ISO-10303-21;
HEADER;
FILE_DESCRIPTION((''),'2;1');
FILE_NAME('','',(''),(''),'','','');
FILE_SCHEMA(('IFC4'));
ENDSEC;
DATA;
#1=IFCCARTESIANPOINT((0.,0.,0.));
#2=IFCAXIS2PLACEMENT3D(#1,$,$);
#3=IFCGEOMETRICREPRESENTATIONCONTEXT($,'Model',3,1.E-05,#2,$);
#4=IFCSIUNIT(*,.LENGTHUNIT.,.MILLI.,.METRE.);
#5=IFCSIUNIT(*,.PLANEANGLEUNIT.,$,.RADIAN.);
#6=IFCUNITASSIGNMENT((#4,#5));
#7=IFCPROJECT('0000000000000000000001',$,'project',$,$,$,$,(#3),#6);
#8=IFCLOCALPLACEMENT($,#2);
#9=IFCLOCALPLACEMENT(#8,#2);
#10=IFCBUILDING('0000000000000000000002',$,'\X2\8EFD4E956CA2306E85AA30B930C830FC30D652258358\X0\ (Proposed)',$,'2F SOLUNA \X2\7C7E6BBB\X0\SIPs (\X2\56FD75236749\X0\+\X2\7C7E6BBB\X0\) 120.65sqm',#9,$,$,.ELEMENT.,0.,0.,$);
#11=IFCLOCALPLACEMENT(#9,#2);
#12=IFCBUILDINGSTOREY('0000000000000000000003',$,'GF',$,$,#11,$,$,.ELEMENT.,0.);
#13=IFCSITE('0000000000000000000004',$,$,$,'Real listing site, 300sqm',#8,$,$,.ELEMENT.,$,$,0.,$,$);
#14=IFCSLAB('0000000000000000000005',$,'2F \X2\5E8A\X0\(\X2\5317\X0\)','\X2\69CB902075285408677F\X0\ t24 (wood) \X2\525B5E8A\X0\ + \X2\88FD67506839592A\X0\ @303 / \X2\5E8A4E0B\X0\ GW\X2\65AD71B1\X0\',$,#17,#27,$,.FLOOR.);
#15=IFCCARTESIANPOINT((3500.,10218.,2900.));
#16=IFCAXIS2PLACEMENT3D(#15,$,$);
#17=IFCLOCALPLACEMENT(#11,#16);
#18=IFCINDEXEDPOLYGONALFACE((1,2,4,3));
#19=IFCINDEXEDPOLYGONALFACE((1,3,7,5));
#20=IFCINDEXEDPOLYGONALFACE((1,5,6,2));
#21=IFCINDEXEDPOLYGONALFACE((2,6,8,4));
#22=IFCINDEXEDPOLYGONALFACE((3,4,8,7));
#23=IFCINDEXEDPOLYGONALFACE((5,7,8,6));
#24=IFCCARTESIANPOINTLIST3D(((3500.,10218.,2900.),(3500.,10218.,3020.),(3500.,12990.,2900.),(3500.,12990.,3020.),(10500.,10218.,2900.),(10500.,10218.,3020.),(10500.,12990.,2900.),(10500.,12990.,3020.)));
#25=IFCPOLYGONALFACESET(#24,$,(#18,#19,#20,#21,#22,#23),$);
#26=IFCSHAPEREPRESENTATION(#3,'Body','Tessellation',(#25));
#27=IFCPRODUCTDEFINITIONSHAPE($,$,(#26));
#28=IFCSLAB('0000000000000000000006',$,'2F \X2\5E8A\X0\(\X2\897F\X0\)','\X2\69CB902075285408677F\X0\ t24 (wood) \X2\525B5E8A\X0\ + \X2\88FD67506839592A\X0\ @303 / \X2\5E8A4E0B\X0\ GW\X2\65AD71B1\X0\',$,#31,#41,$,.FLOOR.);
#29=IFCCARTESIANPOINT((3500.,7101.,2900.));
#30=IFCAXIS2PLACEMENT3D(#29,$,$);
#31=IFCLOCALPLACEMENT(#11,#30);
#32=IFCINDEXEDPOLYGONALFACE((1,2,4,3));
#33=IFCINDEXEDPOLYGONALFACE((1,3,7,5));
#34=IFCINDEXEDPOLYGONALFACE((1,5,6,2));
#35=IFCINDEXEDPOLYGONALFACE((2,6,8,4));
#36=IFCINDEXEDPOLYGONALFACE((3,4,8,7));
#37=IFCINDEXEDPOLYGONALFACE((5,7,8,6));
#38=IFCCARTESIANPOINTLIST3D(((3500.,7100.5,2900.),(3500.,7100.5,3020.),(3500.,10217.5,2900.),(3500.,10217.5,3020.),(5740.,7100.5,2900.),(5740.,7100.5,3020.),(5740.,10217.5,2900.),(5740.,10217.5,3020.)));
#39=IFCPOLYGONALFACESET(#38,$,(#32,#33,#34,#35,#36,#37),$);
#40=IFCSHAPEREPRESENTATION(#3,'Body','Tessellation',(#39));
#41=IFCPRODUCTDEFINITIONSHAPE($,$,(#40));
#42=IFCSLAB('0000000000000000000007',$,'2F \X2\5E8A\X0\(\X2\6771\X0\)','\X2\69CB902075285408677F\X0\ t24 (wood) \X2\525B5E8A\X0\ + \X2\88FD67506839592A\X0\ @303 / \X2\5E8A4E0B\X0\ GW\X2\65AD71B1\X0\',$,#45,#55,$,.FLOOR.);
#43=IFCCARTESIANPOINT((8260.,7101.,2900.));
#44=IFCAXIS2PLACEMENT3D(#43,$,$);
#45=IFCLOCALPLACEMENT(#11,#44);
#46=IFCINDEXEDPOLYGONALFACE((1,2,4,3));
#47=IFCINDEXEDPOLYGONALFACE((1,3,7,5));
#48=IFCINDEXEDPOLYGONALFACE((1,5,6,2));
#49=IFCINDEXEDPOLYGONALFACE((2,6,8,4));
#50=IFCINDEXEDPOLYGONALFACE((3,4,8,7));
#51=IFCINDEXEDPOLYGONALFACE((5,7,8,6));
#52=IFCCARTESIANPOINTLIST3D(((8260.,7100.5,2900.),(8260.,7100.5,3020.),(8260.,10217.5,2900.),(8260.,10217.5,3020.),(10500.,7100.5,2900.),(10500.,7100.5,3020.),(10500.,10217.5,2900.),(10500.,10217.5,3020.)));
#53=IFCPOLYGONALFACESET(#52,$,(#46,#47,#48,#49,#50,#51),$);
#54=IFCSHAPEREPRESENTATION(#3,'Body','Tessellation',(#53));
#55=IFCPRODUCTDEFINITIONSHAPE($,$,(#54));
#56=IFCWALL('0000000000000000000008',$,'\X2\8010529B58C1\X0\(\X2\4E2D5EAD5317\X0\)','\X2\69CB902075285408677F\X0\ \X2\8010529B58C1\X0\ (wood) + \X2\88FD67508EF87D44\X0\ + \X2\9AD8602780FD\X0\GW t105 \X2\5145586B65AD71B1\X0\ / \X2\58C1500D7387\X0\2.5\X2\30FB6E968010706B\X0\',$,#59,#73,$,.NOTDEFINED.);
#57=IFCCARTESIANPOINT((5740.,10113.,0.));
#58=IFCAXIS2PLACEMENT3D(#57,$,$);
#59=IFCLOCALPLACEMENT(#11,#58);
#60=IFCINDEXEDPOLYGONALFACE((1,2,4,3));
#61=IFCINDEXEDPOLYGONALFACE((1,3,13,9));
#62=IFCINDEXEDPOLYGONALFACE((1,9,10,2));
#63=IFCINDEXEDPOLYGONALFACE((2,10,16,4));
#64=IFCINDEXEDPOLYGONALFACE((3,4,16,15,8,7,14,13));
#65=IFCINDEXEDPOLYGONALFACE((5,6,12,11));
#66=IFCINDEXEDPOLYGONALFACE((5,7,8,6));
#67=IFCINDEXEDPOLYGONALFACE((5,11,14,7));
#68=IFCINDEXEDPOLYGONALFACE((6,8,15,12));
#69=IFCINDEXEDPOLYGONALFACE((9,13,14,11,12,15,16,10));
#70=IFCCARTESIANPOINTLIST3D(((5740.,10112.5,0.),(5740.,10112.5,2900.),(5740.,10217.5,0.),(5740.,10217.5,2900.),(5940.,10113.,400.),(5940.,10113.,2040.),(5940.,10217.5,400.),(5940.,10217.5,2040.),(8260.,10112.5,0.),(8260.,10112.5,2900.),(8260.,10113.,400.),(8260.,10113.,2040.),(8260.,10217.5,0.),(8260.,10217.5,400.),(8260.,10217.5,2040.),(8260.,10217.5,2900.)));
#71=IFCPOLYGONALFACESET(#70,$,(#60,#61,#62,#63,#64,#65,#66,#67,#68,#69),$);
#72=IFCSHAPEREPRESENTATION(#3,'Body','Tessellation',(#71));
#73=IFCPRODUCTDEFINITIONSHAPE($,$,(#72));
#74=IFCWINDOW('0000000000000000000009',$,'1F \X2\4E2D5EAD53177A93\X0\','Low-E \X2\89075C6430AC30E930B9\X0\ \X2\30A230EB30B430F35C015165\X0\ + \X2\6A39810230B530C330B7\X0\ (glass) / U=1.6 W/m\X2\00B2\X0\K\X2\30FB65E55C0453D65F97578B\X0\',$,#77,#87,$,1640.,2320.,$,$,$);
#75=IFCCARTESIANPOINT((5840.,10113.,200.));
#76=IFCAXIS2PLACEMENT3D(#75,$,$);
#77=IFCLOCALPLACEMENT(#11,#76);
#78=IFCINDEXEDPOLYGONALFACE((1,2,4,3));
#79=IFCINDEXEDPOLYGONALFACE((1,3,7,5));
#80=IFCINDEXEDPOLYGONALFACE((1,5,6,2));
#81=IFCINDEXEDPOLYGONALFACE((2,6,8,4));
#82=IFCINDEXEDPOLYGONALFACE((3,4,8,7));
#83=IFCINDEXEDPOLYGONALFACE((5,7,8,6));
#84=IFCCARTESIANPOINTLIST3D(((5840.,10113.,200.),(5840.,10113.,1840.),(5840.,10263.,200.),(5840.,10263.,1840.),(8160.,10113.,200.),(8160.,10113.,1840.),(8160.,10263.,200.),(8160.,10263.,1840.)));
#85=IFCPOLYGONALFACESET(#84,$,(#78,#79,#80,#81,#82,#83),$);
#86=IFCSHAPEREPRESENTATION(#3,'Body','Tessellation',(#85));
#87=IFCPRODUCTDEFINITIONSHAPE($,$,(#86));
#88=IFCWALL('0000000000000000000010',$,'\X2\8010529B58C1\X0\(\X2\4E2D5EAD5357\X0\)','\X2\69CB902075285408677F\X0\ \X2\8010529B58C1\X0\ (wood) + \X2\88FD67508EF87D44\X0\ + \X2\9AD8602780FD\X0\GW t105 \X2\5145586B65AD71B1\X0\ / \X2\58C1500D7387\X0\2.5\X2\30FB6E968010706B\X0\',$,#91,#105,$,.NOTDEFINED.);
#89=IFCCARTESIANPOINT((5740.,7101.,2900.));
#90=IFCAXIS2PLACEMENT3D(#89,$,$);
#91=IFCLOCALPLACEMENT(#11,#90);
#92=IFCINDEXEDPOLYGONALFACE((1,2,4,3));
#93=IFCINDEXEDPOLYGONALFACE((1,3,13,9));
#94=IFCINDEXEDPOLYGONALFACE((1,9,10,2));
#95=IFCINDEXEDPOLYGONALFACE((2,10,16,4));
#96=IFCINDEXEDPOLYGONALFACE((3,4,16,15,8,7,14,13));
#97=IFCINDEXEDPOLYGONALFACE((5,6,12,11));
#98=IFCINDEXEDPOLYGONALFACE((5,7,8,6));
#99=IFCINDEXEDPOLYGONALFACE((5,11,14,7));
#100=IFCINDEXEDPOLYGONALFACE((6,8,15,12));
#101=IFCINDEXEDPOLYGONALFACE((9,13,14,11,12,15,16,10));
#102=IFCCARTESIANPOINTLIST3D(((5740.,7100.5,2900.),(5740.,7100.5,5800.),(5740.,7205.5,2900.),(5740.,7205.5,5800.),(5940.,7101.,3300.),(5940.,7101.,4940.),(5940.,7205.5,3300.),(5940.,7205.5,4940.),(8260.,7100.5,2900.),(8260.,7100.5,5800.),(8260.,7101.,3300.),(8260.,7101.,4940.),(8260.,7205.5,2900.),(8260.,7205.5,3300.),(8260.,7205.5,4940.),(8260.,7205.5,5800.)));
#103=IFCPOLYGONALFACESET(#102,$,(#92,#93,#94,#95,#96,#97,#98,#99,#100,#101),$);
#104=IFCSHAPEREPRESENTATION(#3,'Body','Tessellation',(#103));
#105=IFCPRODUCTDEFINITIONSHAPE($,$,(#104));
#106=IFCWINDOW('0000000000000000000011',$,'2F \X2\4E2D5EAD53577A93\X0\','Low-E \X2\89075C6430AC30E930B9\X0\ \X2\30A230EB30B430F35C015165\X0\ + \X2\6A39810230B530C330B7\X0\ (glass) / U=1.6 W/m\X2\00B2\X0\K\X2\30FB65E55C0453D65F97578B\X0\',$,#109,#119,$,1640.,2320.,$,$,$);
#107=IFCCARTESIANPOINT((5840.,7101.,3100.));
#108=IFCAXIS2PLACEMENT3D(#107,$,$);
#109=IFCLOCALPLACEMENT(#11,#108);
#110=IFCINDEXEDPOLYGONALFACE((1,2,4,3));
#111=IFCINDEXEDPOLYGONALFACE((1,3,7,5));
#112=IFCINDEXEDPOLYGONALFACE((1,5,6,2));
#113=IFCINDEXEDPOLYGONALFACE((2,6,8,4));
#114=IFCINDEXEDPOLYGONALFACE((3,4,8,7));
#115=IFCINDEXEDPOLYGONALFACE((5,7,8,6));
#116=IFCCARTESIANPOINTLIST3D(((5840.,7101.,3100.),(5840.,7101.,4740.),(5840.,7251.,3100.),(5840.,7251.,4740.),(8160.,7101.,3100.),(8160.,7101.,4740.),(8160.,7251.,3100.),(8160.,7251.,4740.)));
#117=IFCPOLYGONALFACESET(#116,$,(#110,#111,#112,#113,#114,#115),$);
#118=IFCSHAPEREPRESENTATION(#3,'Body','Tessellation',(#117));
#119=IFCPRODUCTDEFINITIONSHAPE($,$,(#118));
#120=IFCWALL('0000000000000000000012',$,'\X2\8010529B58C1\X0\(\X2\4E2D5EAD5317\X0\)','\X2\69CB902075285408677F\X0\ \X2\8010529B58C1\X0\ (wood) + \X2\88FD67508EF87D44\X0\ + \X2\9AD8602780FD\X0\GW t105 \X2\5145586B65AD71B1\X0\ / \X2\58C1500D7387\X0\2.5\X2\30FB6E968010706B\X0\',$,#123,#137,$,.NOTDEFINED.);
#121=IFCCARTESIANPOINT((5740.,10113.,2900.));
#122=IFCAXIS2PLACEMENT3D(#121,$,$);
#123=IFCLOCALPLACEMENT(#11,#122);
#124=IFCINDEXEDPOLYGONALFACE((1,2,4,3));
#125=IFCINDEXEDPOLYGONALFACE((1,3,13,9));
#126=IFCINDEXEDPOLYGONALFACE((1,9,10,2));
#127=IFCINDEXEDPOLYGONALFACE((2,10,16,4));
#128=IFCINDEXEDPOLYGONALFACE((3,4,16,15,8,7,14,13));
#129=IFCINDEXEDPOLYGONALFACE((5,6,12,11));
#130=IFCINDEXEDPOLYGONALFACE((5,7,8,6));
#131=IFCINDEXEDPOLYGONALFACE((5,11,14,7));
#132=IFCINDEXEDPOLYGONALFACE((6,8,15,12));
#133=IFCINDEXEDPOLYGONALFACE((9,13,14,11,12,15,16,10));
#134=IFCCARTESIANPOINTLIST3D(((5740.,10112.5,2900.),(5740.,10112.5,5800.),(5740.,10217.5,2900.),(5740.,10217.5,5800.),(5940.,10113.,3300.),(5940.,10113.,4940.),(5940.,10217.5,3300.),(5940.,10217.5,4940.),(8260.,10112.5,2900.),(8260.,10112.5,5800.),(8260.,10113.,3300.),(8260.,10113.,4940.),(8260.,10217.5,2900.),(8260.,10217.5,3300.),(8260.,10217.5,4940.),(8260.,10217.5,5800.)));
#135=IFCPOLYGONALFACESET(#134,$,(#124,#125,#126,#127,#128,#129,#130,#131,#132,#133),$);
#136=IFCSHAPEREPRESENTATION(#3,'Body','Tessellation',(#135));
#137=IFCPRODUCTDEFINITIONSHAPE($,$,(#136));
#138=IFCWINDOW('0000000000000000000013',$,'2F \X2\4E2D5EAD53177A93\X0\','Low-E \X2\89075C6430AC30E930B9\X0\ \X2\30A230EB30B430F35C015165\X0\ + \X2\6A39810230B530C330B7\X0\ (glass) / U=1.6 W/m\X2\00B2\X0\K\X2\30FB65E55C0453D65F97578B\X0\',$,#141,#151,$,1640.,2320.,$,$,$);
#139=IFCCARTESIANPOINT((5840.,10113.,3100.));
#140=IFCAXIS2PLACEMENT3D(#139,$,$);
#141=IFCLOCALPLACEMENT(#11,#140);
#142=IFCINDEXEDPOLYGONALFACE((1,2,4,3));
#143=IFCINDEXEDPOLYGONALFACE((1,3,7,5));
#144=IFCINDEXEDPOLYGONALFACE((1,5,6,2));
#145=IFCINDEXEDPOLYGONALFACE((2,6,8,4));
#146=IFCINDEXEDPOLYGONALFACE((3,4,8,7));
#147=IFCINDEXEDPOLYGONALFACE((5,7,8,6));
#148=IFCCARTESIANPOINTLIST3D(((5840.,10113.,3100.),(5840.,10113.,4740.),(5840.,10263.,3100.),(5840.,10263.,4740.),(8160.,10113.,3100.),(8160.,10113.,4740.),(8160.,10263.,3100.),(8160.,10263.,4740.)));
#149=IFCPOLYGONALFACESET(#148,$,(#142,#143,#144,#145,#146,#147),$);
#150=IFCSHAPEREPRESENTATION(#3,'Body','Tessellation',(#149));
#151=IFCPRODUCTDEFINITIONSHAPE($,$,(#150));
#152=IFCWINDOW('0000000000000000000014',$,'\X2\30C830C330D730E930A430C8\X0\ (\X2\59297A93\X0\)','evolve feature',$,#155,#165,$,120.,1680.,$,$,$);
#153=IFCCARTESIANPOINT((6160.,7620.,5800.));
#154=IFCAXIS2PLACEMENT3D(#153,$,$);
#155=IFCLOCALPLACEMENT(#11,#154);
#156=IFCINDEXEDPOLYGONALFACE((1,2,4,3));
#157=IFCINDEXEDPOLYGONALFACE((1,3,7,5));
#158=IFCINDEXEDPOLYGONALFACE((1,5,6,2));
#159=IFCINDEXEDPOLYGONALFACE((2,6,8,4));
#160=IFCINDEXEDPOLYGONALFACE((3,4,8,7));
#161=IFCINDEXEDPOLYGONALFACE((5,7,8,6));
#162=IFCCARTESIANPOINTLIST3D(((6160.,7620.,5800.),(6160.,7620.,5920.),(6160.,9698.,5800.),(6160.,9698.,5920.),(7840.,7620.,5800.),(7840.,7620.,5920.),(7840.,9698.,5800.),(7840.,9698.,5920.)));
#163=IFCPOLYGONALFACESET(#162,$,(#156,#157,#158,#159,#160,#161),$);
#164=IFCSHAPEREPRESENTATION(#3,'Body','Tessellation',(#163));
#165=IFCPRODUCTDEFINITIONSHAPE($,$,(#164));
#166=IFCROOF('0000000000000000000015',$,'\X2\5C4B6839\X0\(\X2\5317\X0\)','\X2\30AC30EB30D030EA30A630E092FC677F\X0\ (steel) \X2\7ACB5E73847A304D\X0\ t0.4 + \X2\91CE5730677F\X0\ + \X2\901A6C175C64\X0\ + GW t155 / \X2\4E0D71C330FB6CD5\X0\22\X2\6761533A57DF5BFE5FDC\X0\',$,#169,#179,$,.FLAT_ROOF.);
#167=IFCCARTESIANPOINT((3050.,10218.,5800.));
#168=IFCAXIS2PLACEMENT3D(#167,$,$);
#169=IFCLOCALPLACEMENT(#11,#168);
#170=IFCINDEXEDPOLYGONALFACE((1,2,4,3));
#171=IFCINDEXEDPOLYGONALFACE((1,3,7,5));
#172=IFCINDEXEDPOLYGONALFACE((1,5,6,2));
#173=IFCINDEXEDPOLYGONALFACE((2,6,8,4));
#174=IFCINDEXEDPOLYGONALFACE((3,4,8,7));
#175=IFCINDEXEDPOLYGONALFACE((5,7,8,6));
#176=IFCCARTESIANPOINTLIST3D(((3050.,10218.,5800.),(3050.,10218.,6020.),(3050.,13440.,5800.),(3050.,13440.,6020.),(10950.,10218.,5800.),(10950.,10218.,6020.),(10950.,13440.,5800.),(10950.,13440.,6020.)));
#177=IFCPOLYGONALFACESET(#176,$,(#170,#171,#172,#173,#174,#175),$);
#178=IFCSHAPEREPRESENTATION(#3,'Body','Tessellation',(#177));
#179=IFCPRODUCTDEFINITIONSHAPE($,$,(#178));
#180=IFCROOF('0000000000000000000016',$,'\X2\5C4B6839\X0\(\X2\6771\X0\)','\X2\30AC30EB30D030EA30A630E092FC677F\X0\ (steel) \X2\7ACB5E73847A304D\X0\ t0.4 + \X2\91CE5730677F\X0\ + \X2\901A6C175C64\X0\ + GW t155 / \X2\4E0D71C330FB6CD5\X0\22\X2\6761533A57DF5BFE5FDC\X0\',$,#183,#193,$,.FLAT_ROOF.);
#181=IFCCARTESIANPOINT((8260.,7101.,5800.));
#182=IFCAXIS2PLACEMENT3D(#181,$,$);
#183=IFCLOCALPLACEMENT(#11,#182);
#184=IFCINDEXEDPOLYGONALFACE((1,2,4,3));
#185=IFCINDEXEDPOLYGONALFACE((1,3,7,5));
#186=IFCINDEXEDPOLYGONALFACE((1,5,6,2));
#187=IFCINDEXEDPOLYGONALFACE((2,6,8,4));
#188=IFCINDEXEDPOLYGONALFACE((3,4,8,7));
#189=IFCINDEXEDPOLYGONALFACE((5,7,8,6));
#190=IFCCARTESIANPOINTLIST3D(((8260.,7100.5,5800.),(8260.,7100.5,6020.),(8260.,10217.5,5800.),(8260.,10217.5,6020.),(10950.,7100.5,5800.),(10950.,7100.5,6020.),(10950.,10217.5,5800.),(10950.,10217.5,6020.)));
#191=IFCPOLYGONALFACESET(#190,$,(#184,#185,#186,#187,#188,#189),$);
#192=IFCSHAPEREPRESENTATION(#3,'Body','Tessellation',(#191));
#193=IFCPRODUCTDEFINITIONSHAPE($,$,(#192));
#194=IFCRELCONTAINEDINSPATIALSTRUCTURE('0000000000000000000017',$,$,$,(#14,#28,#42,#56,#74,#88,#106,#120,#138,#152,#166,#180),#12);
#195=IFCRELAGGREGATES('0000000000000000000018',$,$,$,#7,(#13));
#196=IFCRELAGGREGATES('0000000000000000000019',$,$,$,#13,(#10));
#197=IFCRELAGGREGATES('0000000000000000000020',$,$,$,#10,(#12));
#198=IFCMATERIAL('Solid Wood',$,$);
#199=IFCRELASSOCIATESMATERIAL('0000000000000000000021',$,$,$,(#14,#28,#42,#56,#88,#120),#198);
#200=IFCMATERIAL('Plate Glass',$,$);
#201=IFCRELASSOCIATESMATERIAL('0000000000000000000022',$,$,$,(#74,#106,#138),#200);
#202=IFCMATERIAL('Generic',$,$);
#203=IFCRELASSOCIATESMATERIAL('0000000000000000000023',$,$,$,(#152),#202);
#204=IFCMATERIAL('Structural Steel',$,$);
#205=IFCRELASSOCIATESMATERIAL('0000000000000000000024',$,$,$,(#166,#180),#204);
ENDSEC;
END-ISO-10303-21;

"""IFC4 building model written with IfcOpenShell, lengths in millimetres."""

from ifc_helpers import new_model, si_unit, frame, frame_2d, origin, place, context, project, spatial, rectangle, extrude, material, element, fill, save


model = new_model("IFC4")

# Units and contexts
model_context = context("Model", 3, precision=1e-05, world=origin())
ifc_project = project(units=[si_unit("LENGTHUNIT", "METRE", prefix="MILLI"), si_unit("PLANEANGLEUNIT", "RADIAN")], contexts=[model_context])

# Site, building, storey
site_placement = place(None, origin())
site = spatial("IfcSite", under=ifc_project, at=site_placement, ObjectType="Real listing site, 300sqm", CompositionType="ELEMENT", RefElevation=0.0)
building_placement = place(site_placement, origin())
building = spatial("IfcBuilding", under=site, at=building_placement, Name="軽井沢の薪ストーブ別荘 (Proposed)", ObjectType="2F SOLUNA 籾殻SIPs (国産杉+籾殻) 120.65sqm", CompositionType="ELEMENT", ElevationOfRefHeight=0.0, ElevationOfTerrain=0.0)
storey_placement = place(building_placement, origin())
storey = spatial("IfcBuildingStorey", under=building, at=storey_placement, Name="GF", CompositionType="ELEMENT", Elevation=0.0)

# Slabs
ifc_material_1 = material(Name="Solid Wood")
slab_1_placement = place(storey_placement, frame((3500.0, 10218.0, 2900.0)))
element("IfcSlab", 1, at=slab_1_placement, inside=storey, material=ifc_material_1, Name="2F 床(北)", Description="構造用合板 t24 (wood) 剛床 + 製材根太 @303 / 床下 GW断熱", PredefinedType="FLOOR", context=model_context, shape_type="SweptSolid", body=[
    extrude(rectangle(XDim=7000.0, YDim=2772.0, at=frame_2d((3500.0, 1386.0))), frame((3500.0, 10218.0, 2900.0)), (0.0, 0.0, 1.0), 120.0),
])
slab_2_placement = place(storey_placement, frame((3500.0, 7101.0, 2900.0)))
element("IfcSlab", 2, at=slab_2_placement, inside=storey, material=ifc_material_1, Name="2F 床(西)", Description="構造用合板 t24 (wood) 剛床 + 製材根太 @303 / 床下 GW断熱", PredefinedType="FLOOR", context=model_context, shape_type="SweptSolid", body=[
    extrude(rectangle(XDim=2240.0, YDim=3117.0, at=frame_2d((1120.0, 1558.0))), frame((3500.0, 7101.0, 2900.0)), (0.0, 0.0, 1.0), 120.0),
])
slab_3_placement = place(storey_placement, frame((8260.0, 7101.0, 2900.0)))
element("IfcSlab", 3, at=slab_3_placement, inside=storey, material=ifc_material_1, Name="2F 床(東)", Description="構造用合板 t24 (wood) 剛床 + 製材根太 @303 / 床下 GW断熱", PredefinedType="FLOOR", context=model_context, shape_type="SweptSolid", body=[
    extrude(rectangle(XDim=2240.0, YDim=3117.0, at=frame_2d((1120.0, 1558.0))), frame((8260.0, 7101.0, 2900.0)), (0.0, 0.0, 1.0), 120.0),
])

# Wall, opening, window
wall_1_placement = place(storey_placement, frame((5740.0, 10113.0, 0.0)))
wall_1 = element("IfcWall", 4, at=wall_1_placement, inside=storey, material=ifc_material_1, Name="耐力壁(中庭北)", Description="構造用合板 耐力壁 (wood) + 製材軸組 + 高性能GW t105 充填断熱 / 壁倍率2.5・準耐火", PredefinedType="NOTDEFINED", context=model_context, shape_type="SweptSolid", body=[
    extrude(rectangle(XDim=2520.0, YDim=105.0, at=frame_2d((1260.0, 52.0))), frame((5740.0, 10113.0, 0.0)), (0.0, 0.0, 1.0), 2900.0),
])
opening_1_placement = place(storey_placement, frame((5840.0, 10113.0, 200.0)))
opening_1 = element("IfcOpeningElement", 5, at=opening_1_placement, cuts=wall_1, PredefinedType="NOTDEFINED", context=model_context, shape_type="SweptSolid", body=[
    extrude(rectangle(XDim=2320.0, YDim=150.0, at=frame_2d((1160.0, 75.0))), frame((5840.0, 10113.0, 200.0)), (0.0, 0.0, 1.0), 1640.0),
])
ifc_material_2 = material(Name="Plate Glass")
window_1_placement = place(storey_placement, frame((5840.0, 10113.0, 200.0)))
window_1 = element("IfcWindow", 6, at=window_1_placement, inside=storey, material=ifc_material_2, Name="1F 中庭北窓", Description="Low-E 複層ガラス アルゴン封入 + 樹脂サッシ (glass) / U=1.6 W/m²K・日射取得型", OverallHeight=1640.0, OverallWidth=2320.0, context=model_context, shape_type="SweptSolid", body=[
    extrude(rectangle(XDim=2320.0, YDim=150.0, at=frame_2d((1160.0, 75.0))), frame((5840.0, 10113.0, 200.0)), (0.0, 0.0, 1.0), 1640.0),
])
fill(opening_1, window_1)

# Walls, openings, windows
wall_2_placement = place(storey_placement, frame((5740.0, 7101.0, 2900.0)))
wall_2 = element("IfcWall", 7, at=wall_2_placement, inside=storey, material=ifc_material_1, Name="耐力壁(中庭南)", Description="構造用合板 耐力壁 (wood) + 製材軸組 + 高性能GW t105 充填断熱 / 壁倍率2.5・準耐火", PredefinedType="NOTDEFINED", context=model_context, shape_type="SweptSolid", body=[
    extrude(rectangle(XDim=2520.0, YDim=105.0, at=frame_2d((1260.0, 52.0))), frame((5740.0, 7101.0, 2900.0)), (0.0, 0.0, 1.0), 2900.0),
])
opening_2_placement = place(storey_placement, frame((5840.0, 7101.0, 3100.0)))
opening_2 = element("IfcOpeningElement", 8, at=opening_2_placement, cuts=wall_2, PredefinedType="NOTDEFINED", context=model_context, shape_type="SweptSolid", body=[
    extrude(rectangle(XDim=2320.0, YDim=150.0, at=frame_2d((1160.0, 75.0))), frame((5840.0, 7101.0, 3100.0)), (0.0, 0.0, 1.0), 1640.0),
])
window_2_placement = place(storey_placement, frame((5840.0, 7101.0, 3100.0)))
window_2 = element("IfcWindow", 9, at=window_2_placement, inside=storey, material=ifc_material_2, Name="2F 中庭南窓", Description="Low-E 複層ガラス アルゴン封入 + 樹脂サッシ (glass) / U=1.6 W/m²K・日射取得型", OverallHeight=1640.0, OverallWidth=2320.0, context=model_context, shape_type="SweptSolid", body=[
    extrude(rectangle(XDim=2320.0, YDim=150.0, at=frame_2d((1160.0, 75.0))), frame((5840.0, 7101.0, 3100.0)), (0.0, 0.0, 1.0), 1640.0),
])
fill(opening_2, window_2)
wall_3_placement = place(storey_placement, frame((5740.0, 10113.0, 2900.0)))
wall_3 = element("IfcWall", 10, at=wall_3_placement, inside=storey, material=ifc_material_1, Name="耐力壁(中庭北)", Description="構造用合板 耐力壁 (wood) + 製材軸組 + 高性能GW t105 充填断熱 / 壁倍率2.5・準耐火", PredefinedType="NOTDEFINED", context=model_context, shape_type="SweptSolid", body=[
    extrude(rectangle(XDim=2520.0, YDim=105.0, at=frame_2d((1260.0, 52.0))), frame((5740.0, 10113.0, 2900.0)), (0.0, 0.0, 1.0), 2900.0),
])
opening_3_placement = place(storey_placement, frame((5840.0, 10113.0, 3100.0)))
opening_3 = element("IfcOpeningElement", 11, at=opening_3_placement, cuts=wall_3, PredefinedType="NOTDEFINED", context=model_context, shape_type="SweptSolid", body=[
    extrude(rectangle(XDim=2320.0, YDim=150.0, at=frame_2d((1160.0, 75.0))), frame((5840.0, 10113.0, 3100.0)), (0.0, 0.0, 1.0), 1640.0),
])
window_3_placement = place(storey_placement, frame((5840.0, 10113.0, 3100.0)))
window_3 = element("IfcWindow", 12, at=window_3_placement, inside=storey, material=ifc_material_2, Name="2F 中庭北窓", Description="Low-E 複層ガラス アルゴン封入 + 樹脂サッシ (glass) / U=1.6 W/m²K・日射取得型", OverallHeight=1640.0, OverallWidth=2320.0, context=model_context, shape_type="SweptSolid", body=[
    extrude(rectangle(XDim=2320.0, YDim=150.0, at=frame_2d((1160.0, 75.0))), frame((5840.0, 10113.0, 3100.0)), (0.0, 0.0, 1.0), 1640.0),
])
fill(opening_3, window_3)

# Window
ifc_material_3 = material(Name="Generic")
window_4_placement = place(storey_placement, frame((6160.0, 7620.0, 5800.0)))
element("IfcWindow", 13, at=window_4_placement, inside=storey, material=ifc_material_3, Name="トップライト (天窓)", Description="evolve feature", OverallHeight=120.0, OverallWidth=1680.0, context=model_context, shape_type="SweptSolid", body=[
    extrude(rectangle(XDim=1680.0, YDim=2078.0, at=frame_2d((840.0, 1039.0))), frame((6160.0, 7620.0, 5800.0)), (0.0, 0.0, 1.0), 120.0),
])

# Roofs
ifc_material_4 = material(Name="Structural Steel")
roof_1_placement = place(storey_placement, frame((3050.0, 10218.0, 5800.0)))
element("IfcRoof", 14, at=roof_1_placement, inside=storey, material=ifc_material_4, Name="屋根(北)", Description="ガルバリウム鋼板 (steel) 立平葺き t0.4 + 野地板 + 通気層 + GW t155 / 不燃・法22条区域対応", PredefinedType="FLAT_ROOF", context=model_context, shape_type="SweptSolid", body=[
    extrude(rectangle(XDim=7900.0, YDim=3222.0, at=frame_2d((3950.0, 1611.0))), frame((3050.0, 10218.0, 5800.0)), (0.0, 0.0, 1.0), 220.0),
])
roof_2_placement = place(storey_placement, frame((8260.0, 7101.0, 5800.0)))
element("IfcRoof", 15, at=roof_2_placement, inside=storey, material=ifc_material_4, Name="屋根(東)", Description="ガルバリウム鋼板 (steel) 立平葺き t0.4 + 野地板 + 通気層 + GW t155 / 不燃・法22条区域対応", PredefinedType="FLAT_ROOF", context=model_context, shape_type="SweptSolid", body=[
    extrude(rectangle(XDim=2690.0, YDim=3117.0, at=frame_2d((1345.0, 1558.0))), frame((8260.0, 7101.0, 5800.0)), (0.0, 0.0, 1.0), 220.0),
])

save(model, "model.ifc")
